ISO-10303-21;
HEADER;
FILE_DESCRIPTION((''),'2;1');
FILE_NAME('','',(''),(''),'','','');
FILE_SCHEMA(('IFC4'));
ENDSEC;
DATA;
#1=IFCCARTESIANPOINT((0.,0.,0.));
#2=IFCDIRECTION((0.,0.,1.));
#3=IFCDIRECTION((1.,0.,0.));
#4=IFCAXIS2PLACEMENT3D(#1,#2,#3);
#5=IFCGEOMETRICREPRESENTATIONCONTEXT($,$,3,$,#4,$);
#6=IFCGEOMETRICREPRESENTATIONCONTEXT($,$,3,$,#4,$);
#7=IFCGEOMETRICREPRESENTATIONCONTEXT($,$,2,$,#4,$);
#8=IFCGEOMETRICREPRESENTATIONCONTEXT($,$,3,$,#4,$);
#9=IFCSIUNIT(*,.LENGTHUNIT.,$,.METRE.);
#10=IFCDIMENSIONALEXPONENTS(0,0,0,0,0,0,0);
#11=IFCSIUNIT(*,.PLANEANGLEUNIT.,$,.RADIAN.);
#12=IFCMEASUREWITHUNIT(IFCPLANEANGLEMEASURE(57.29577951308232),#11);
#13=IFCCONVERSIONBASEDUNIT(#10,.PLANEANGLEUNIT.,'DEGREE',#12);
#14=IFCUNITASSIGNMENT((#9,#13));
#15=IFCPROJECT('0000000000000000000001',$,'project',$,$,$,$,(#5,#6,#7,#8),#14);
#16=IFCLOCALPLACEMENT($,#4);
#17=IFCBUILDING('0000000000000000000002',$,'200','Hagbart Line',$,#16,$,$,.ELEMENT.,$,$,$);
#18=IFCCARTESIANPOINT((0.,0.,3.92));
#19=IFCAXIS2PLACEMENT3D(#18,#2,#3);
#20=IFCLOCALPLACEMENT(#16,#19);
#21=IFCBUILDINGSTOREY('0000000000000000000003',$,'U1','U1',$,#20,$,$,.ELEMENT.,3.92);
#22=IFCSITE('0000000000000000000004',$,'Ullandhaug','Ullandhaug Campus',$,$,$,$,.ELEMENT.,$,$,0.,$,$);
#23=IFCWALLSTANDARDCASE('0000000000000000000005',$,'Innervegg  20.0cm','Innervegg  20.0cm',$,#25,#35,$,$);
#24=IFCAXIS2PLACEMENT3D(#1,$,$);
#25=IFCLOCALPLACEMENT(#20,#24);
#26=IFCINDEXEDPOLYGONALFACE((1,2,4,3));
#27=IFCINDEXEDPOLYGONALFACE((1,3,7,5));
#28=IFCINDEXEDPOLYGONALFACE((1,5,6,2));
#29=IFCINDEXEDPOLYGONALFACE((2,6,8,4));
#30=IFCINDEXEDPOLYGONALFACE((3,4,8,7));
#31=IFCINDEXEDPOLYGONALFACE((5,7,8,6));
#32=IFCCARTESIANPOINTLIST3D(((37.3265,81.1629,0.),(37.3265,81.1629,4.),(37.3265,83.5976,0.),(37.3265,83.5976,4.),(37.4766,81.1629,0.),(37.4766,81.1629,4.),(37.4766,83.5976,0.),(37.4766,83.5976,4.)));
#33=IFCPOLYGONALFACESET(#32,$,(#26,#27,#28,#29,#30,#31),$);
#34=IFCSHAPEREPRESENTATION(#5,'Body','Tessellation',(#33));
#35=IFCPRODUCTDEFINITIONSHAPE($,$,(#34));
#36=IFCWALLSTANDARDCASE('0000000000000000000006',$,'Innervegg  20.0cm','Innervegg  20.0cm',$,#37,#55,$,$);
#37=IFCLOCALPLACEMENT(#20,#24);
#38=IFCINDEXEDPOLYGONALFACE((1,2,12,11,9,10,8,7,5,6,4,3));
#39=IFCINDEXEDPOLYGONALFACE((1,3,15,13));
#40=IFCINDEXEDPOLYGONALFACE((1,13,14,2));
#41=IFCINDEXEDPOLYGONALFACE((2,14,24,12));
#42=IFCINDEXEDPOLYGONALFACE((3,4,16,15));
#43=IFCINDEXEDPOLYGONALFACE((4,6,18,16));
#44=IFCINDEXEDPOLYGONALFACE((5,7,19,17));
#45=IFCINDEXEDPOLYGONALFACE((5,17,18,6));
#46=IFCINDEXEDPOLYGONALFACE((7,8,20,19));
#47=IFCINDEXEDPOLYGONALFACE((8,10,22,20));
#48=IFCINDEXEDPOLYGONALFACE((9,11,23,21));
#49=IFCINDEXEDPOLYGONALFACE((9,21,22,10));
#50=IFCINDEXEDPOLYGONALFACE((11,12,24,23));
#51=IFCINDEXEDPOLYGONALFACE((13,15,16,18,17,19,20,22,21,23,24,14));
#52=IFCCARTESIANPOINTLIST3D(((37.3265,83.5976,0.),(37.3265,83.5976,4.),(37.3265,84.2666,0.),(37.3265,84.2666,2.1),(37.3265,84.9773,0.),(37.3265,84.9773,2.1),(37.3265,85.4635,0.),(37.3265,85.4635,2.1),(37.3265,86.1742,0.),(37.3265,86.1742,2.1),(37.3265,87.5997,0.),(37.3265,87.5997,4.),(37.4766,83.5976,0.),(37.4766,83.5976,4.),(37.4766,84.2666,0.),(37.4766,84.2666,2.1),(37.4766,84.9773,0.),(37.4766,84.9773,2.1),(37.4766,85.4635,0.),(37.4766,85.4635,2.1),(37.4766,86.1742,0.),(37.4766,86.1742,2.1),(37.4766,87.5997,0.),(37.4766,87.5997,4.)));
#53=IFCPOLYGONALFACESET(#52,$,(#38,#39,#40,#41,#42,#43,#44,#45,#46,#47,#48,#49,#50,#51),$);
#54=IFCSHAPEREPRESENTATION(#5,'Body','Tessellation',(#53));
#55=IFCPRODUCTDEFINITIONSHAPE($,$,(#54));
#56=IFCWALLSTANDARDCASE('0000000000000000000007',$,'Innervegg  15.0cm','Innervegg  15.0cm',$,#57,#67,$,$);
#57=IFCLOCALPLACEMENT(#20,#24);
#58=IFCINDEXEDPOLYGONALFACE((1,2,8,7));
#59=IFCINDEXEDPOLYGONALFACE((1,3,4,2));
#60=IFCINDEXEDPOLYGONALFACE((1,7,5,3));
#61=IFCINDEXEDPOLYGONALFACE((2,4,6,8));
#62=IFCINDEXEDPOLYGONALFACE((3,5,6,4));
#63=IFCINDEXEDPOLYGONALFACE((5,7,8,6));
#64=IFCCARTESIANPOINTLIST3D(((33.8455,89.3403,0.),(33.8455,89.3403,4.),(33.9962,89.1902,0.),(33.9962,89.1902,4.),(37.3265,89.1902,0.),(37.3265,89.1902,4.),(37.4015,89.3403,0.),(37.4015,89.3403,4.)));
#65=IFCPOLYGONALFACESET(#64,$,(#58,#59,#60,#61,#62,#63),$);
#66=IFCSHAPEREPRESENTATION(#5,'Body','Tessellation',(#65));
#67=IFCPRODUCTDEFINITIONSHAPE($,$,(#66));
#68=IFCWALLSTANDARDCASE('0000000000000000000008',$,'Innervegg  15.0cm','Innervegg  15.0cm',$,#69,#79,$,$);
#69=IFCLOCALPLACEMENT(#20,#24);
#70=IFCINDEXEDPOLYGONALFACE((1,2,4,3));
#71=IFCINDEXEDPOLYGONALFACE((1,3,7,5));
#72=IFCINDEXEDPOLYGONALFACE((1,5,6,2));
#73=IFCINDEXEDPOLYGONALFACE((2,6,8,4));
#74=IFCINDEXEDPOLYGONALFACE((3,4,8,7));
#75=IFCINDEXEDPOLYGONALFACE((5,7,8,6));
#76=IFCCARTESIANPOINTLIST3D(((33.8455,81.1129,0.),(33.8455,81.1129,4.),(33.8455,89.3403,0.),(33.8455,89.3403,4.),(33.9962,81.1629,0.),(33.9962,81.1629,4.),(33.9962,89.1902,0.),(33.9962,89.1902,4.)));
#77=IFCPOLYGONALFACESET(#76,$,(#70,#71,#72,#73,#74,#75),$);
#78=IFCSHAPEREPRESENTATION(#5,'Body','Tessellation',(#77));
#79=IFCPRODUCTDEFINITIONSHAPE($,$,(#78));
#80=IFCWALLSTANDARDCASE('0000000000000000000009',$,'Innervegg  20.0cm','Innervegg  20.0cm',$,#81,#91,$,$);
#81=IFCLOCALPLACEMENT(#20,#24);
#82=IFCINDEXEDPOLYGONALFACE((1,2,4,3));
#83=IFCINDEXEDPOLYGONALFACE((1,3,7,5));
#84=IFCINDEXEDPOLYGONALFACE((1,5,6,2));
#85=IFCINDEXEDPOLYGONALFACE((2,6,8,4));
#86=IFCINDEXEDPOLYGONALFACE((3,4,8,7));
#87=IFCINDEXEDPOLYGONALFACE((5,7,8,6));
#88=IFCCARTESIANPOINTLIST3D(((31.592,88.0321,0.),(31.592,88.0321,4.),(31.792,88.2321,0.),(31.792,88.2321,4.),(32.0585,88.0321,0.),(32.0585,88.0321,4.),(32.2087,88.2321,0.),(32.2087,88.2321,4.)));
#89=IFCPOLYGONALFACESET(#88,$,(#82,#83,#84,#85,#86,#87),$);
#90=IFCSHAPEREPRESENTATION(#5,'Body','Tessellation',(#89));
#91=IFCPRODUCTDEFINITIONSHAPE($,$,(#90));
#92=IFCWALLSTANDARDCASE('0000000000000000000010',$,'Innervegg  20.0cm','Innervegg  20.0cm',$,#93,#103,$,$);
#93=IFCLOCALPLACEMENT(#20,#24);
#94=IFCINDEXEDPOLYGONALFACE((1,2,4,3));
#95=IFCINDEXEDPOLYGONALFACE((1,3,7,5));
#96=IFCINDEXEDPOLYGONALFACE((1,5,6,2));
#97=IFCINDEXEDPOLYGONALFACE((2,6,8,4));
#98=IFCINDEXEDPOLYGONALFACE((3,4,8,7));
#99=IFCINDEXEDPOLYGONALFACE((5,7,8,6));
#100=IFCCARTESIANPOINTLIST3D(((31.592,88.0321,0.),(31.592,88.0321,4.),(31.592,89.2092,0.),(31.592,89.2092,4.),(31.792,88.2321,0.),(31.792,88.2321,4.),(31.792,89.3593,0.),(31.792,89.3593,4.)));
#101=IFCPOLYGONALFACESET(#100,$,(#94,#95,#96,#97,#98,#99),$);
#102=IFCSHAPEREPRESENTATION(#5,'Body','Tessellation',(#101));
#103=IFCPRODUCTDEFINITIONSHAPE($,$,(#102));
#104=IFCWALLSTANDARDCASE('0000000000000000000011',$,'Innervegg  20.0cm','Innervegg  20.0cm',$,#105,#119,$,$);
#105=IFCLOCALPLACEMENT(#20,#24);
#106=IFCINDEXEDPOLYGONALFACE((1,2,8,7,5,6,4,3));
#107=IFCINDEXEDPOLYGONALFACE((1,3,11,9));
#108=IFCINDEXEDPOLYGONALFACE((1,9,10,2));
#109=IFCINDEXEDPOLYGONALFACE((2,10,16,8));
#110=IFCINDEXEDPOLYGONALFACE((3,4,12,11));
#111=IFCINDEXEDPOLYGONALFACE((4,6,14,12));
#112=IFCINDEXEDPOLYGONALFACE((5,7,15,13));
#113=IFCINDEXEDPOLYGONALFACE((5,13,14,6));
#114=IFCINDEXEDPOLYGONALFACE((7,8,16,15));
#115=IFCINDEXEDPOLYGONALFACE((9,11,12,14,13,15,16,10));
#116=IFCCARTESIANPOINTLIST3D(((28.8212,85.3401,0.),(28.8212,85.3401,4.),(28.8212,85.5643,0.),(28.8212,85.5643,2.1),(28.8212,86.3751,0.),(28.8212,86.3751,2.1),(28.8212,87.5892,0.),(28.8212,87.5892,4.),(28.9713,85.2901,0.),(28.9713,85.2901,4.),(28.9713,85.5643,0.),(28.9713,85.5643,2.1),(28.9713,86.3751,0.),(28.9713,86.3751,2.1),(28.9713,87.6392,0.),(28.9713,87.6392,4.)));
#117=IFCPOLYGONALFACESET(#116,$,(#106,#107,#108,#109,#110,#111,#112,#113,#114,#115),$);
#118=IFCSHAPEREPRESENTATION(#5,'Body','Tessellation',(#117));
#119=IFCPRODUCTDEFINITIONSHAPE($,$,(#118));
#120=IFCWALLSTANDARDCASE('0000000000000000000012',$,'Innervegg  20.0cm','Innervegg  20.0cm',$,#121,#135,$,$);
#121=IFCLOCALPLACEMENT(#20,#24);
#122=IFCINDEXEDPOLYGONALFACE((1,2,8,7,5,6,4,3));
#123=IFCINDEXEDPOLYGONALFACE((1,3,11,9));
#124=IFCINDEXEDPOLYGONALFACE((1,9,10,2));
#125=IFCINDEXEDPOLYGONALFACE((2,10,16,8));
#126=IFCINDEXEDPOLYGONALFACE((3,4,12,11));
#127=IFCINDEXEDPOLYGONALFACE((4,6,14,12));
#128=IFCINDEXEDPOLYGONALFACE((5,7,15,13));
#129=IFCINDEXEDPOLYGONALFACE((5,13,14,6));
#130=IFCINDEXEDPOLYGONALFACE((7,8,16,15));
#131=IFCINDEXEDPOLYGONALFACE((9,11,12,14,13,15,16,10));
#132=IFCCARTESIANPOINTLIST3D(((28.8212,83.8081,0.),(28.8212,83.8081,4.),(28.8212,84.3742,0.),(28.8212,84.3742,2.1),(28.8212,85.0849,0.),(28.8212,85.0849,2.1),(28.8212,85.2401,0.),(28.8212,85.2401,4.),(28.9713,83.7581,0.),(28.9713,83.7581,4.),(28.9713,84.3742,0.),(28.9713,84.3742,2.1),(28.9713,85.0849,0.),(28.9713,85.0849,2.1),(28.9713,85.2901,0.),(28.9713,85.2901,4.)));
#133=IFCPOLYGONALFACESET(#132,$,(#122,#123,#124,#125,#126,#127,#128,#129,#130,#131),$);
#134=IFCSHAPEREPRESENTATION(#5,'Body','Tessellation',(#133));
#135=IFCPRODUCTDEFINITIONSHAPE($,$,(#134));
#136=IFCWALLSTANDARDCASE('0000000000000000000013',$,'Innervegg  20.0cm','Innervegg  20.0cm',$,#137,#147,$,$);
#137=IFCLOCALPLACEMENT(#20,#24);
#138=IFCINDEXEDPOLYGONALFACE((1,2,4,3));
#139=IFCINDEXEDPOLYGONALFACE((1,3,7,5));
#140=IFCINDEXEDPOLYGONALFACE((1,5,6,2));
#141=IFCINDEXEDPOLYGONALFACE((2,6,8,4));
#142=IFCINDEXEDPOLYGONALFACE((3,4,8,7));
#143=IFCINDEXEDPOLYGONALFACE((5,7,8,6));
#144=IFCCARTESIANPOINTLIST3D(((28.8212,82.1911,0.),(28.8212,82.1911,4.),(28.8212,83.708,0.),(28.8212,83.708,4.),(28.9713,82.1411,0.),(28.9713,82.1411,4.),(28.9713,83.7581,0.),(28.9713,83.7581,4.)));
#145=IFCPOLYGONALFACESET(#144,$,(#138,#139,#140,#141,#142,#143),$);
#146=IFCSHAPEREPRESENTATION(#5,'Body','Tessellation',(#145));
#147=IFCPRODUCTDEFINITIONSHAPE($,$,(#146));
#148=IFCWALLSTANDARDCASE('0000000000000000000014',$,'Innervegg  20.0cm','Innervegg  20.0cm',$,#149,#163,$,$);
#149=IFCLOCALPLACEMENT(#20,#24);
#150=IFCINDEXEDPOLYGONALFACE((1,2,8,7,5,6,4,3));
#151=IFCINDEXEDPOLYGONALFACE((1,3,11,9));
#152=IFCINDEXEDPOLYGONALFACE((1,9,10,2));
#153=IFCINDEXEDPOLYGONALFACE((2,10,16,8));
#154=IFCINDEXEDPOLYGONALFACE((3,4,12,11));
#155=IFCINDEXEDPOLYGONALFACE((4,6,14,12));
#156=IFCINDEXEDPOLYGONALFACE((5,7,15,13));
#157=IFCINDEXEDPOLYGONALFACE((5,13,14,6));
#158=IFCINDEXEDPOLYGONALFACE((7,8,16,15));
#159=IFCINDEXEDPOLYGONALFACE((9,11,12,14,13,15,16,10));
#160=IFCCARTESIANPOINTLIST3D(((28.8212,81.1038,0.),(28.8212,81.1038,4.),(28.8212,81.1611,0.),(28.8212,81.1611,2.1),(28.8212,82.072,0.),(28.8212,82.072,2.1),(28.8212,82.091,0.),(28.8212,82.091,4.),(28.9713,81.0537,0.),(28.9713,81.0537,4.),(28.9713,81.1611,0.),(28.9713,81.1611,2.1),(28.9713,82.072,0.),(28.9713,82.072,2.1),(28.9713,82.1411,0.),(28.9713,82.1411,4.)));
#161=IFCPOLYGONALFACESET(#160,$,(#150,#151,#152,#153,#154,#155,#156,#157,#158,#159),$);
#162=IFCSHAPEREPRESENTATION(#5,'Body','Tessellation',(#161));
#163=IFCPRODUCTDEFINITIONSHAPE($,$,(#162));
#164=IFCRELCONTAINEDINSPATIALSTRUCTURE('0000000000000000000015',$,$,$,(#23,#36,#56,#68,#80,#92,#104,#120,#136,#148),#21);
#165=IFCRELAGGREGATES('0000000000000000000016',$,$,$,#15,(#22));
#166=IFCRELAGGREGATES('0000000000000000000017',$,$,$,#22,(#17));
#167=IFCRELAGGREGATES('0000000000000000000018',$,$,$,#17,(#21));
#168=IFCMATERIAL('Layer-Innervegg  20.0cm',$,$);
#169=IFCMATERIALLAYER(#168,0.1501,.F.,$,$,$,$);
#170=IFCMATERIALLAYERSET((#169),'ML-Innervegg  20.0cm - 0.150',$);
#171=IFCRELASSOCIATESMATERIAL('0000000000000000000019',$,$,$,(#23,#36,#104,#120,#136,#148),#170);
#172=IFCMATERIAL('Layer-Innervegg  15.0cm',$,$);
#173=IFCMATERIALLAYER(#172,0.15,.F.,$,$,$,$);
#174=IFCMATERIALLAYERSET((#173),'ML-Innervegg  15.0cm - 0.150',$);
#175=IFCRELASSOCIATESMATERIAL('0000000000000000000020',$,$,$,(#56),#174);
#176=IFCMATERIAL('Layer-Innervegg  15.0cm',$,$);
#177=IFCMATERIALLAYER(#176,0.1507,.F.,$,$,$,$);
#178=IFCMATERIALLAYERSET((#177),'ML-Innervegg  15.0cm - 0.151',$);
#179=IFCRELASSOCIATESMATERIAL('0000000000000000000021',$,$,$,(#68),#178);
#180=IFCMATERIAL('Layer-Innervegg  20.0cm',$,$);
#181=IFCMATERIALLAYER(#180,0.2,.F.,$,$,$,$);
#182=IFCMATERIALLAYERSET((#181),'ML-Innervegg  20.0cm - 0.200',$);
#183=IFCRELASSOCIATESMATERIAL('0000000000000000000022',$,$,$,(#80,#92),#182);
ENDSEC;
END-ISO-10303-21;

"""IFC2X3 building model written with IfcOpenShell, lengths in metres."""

from ifc_helpers import new_model, entity, si_unit, converted_unit, frame, origin_with_axes, place, context, project, spatial, polyline, outline, extrude, material, layer, layer_set, layer_usage, element, save


model = new_model("IFC2X3")

# Units and contexts
context_of_model_1 = context(None, 3, world=origin_with_axes())
context_of_model_2 = context(None, 3, world=origin_with_axes())
context_of_model_3 = context(None, 2, world=origin_with_axes())
context_of_model_4 = context(None, 3, world=origin_with_axes())
ifc_project = project(units=[si_unit("LENGTHUNIT", "METRE"), converted_unit("PLANEANGLEUNIT", "DEGREE", entity("IfcPlaneAngleMeasure", 57.29577951308232), si_unit("PLANEANGLEUNIT", "RADIAN"), dimensions=[0, 0, 0, 0, 0, 0, 0])], contexts=[context_of_model_1, context_of_model_2, context_of_model_3, context_of_model_4])

# Site, building, storey
site = spatial("IfcSite", under=ifc_project, Name="Ullandhaug", Description="Ullandhaug Campus", CompositionType="ELEMENT", RefElevation=0.0)
building_placement = place(None, origin_with_axes())
building = spatial("IfcBuilding", under=site, at=building_placement, Name="200", Description="Hagbart Line", CompositionType="ELEMENT")
storey_placement = place(building_placement, frame((0.0, 0.0, 3.92), z_axis=(0.0, 0.0, 1.0), x_axis=(1.0, 0.0, 0.0)))
storey = spatial("IfcBuildingStorey", under=building, at=storey_placement, Name="U1", Description="U1", CompositionType="ELEMENT", Elevation=3.92)

# Shared definitions
ifc_material_1 = material(Name="Layer-Innervegg  20.0cm")
ifc_layer_1 = layer(ifc_material_1, 0.1501, ventilated=False)
ifc_layer_set_1 = layer_set([ifc_layer_1], Name="ML-Innervegg  20.0cm - 0.150")
ifc_layer_usage_1 = layer_usage(ifc_layer_set_1, "AXIS2", "POSITIVE", 0.0)

# Shared definitions
ifc_material_2 = material(Name="Layer-Innervegg  20.0cm")
ifc_layer_2 = layer(ifc_material_2, 0.2, ventilated=False)
ifc_layer_set_2 = layer_set([ifc_layer_2], Name="ML-Innervegg  20.0cm - 0.200")
ifc_layer_usage_2 = layer_usage(ifc_layer_set_2, "AXIS2", "POSITIVE", 0.0)
ifc_material_3 = material(Name="Layer-Innervegg  15.0cm")
ifc_layer_3 = layer(ifc_material_3, 0.15, ventilated=False)
ifc_layer_set_3 = layer_set([ifc_layer_3], Name="ML-Innervegg  15.0cm - 0.150")
ifc_layer_usage_3 = layer_usage(ifc_layer_set_3, "AXIS2", "POSITIVE", 0.0)

# Wall
wall_1_placement = place(storey_placement, frame((37.3265, 83.5976, 0.0), z_axis=(0.0, 0.0, 1.0), x_axis=(0.0, -1.0, 0.0)))
element("IfcWallStandardCase", 1, at=wall_1_placement, inside=storey, material=ifc_layer_usage_1, Name="Innervegg  20.0cm", Description="Innervegg  20.0cm", context=context_of_model_1, shape_type="SweptSolid", body=[
    extrude(outline(polyline([(0.0, 0.0), (2.4347, 0.0), (2.4347, 0.1502), (0.0, 0.1502), (0.0, 0.0)])), frame((0.0, 0.0, 0.0), z_axis=(0.0, 0.0, 1.0), x_axis=(1.0, 0.0, 0.0)), (0.0, 0.0, 1.0), 4.0),
])

# Wall, openings
wall_2_placement = place(storey_placement, frame((37.4766, 83.5976, 0.0), z_axis=(0.0, 0.0, 1.0), x_axis=(0.0, 1.0, 0.0)))
wall_2 = element("IfcWallStandardCase", 2, at=wall_2_placement, inside=storey, material=ifc_layer_usage_1, Name="Innervegg  20.0cm", Description="Innervegg  20.0cm", context=context_of_model_1, shape_type="SweptSolid", body=[
    extrude(outline(polyline([(0.0, 0.0), (4.0021, 0.0), (4.0021, 0.1502), (0.0, 0.1502), (0.0, 0.0)])), frame((0.0, 0.0, 0.0), z_axis=(0.0, 0.0, 1.0), x_axis=(1.0, 0.0, 0.0)), (0.0, 0.0, 1.0), 4.0),
])
opening_1_placement = place(wall_2_placement, frame((1.8659, 0.1502, 0.0), z_axis=(0.0, 0.0, 1.0), x_axis=(1.0, 0.0, 0.0)))
element("IfcOpeningElement", 3, at=opening_1_placement, cuts=wall_2, context=context_of_model_1, shape_type="SweptSolid", body=[
    extrude(outline(polyline([(0.0, 0.0), (2.1, 0.0), (2.1, 0.7107), (0.0, 0.7107), (0.0, 0.0)])), frame((0.0, 0.0, 0.0), z_axis=(0.0, 1.0, 0.0), x_axis=(0.0, 0.0, 1.0)), (0.0, 0.0, -1.0), 0.1502),
])
opening_2_placement = place(wall_2_placement, frame((0.6691, 0.1502, 0.0), z_axis=(0.0, 0.0, 1.0), x_axis=(1.0, 0.0, 0.0)))
element("IfcOpeningElement", 4, at=opening_2_placement, cuts=wall_2, context=context_of_model_1, shape_type="SweptSolid", body=[
    extrude(outline(polyline([(0.0, 0.0), (2.1, 0.0), (2.1, 0.7107), (0.0, 0.7107), (0.0, 0.0)])), frame((0.0, 0.0, 0.0), z_axis=(0.0, 1.0, 0.0), x_axis=(0.0, 0.0, 1.0)), (0.0, 0.0, -1.0), 0.1502),
])

# Walls
wall_3_placement = place(storey_placement, frame((37.4015, 89.3403, 0.0), z_axis=(0.0, 0.0, 1.0), x_axis=(-1.0, 0.0, 0.0)))
element("IfcWallStandardCase", 5, at=wall_3_placement, inside=storey, material=ifc_layer_usage_3, Name="Innervegg  15.0cm", Description="Innervegg  15.0cm", context=context_of_model_1, shape_type="SweptSolid", body=[
    extrude(outline(polyline([(0.0, 0.0), (3.556, 0.0), (3.4053, 0.1501), (0.0751, 0.1501), (0.0, 0.0)])), frame((0.0, 0.0, 0.0), z_axis=(0.0, 0.0, 1.0), x_axis=(1.0, 0.0, 0.0)), (0.0, 0.0, 1.0), 4.0),
])
ifc_material_4 = material(Name="Layer-Innervegg  15.0cm")
ifc_layer_4 = layer(ifc_material_4, 0.1507, ventilated=False)
ifc_layer_set_4 = layer_set([ifc_layer_4], Name="ML-Innervegg  15.0cm - 0.151")
ifc_layer_usage_4 = layer_usage(ifc_layer_set_4, "AXIS2", "POSITIVE", 0.0)
wall_4_placement = place(storey_placement, frame((33.8455, 89.3403, 0.0), z_axis=(0.0, 0.0, 1.0), x_axis=(0.0, -1.0, 0.0)))
element("IfcWallStandardCase", 6, at=wall_4_placement, inside=storey, material=ifc_layer_usage_4, Name="Innervegg  15.0cm", Description="Innervegg  15.0cm", context=context_of_model_1, shape_type="SweptSolid", body=[
    extrude(outline(polyline([(0.0, 0.0), (8.2275, 0.0), (8.1774, 0.1507), (0.1501, 0.1507), (0.0, 0.0)])), frame((0.0, 0.0, 0.0), z_axis=(0.0, 0.0, 1.0), x_axis=(1.0, 0.0, 0.0)), (0.0, 0.0, 1.0), 4.0),
])
wall_5_placement = place(storey_placement, frame((32.2087, 88.2321, 0.0), z_axis=(0.0, 0.0, 1.0), x_axis=(-1.0, 0.0, 0.0)))
element("IfcWallStandardCase", 7, at=wall_5_placement, inside=storey, material=ifc_layer_usage_2, Name="Innervegg  20.0cm", Description="Innervegg  20.0cm", context=context_of_model_1, shape_type="SweptSolid", body=[
    extrude(outline(polyline([(0.0, 0.0), (0.4167, 0.0), (0.6167, 0.2), (0.1501, 0.2), (0.0, 0.0)])), frame((0.0, 0.0, 0.0), z_axis=(0.0, 0.0, 1.0), x_axis=(1.0, 0.0, 0.0)), (0.0, 0.0, 1.0), 4.0),
])
wall_6_placement = place(storey_placement, frame((31.792, 88.2321, 0.0), z_axis=(0.0, 0.0, 1.0), x_axis=(0.0, 1.0, 0.0)))
element("IfcWallStandardCase", 8, at=wall_6_placement, inside=storey, material=ifc_layer_usage_2, Name="Innervegg  20.0cm", Description="Innervegg  20.0cm", context=context_of_model_1, shape_type="SweptSolid", body=[
    extrude(outline(polyline([(0.0, 0.0), (1.1272, 0.0), (0.9771, 0.2), (-0.2, 0.2), (0.0, 0.0)])), frame((0.0, 0.0, 0.0), z_axis=(0.0, 0.0, 1.0), x_axis=(1.0, 0.0, 0.0)), (0.0, 0.0, 1.0), 4.0),
])

# Walls, openings
wall_7_placement = place(storey_placement, frame((28.8212, 87.5892, 0.0), z_axis=(0.0, 0.0, 1.0), x_axis=(0.0, -1.0, 0.0)))
wall_7 = element("IfcWallStandardCase", 9, at=wall_7_placement, inside=storey, material=ifc_layer_usage_1, Name="Innervegg  20.0cm", Description="Innervegg  20.0cm", context=context_of_model_1, shape_type="SweptSolid", body=[
    extrude(outline(polyline([(0.0, 0.0), (2.249, 0.0), (2.2991, 0.1501), (-0.05, 0.1501), (0.0, 0.0)])), frame((0.0, 0.0, 0.0), z_axis=(0.0, 0.0, 1.0), x_axis=(1.0, 0.0, 0.0)), (0.0, 0.0, 1.0), 4.0),
])
opening_3_placement = place(wall_7_placement, frame((1.2141, 0.1501, 0.0), z_axis=(0.0, 0.0, 1.0), x_axis=(1.0, 0.0, 0.0)))
element("IfcOpeningElement", 10, at=opening_3_placement, cuts=wall_7, context=context_of_model_1, shape_type="SweptSolid", body=[
    extrude(outline(polyline([(0.0, 0.0), (2.1, 0.0), (2.1, 0.8108), (0.0, 0.8108), (0.0, 0.0)])), frame((0.0, 0.0, 0.0), z_axis=(0.000001, 1.0, 0.0), x_axis=(0.0, 0.0, 1.0)), (0.0, 0.000001, -1.0), 0.1501),
])
wall_8_placement = place(storey_placement, frame((28.8212, 85.2401, 0.0), z_axis=(0.0, 0.0, 1.0), x_axis=(0.0, -1.0, 0.0)))
wall_8 = element("IfcWallStandardCase", 11, at=wall_8_placement, inside=storey, material=ifc_layer_usage_1, Name="Innervegg  20.0cm", Description="Innervegg  20.0cm", context=context_of_model_1, shape_type="SweptSolid", body=[
    extrude(outline(polyline([(0.0, 0.0), (1.4319, 0.0), (1.482, 0.1501), (-0.05, 0.1501), (0.0, 0.0)])), frame((0.0, 0.0, 0.0), z_axis=(0.0, 0.0, 1.0), x_axis=(1.0, 0.0, 0.0)), (0.0, 0.0, 1.0), 4.0),
])
opening_4_placement = place(wall_8_placement, frame((0.1551, 0.1501, 0.0), z_axis=(0.0, 0.0, 1.0), x_axis=(1.0, 0.0, 0.0)))
element("IfcOpeningElement", 12, at=opening_4_placement, cuts=wall_8, context=context_of_model_1, shape_type="SweptSolid", body=[
    extrude(outline(polyline([(0.0, 0.0), (2.1, 0.0), (2.1, 0.7107), (0.0, 0.7107), (0.0, 0.0)])), frame((0.0, 0.0, 0.0), z_axis=(0.0, 1.0, 0.0), x_axis=(0.0, 0.0, 1.0)), (0.0, 0.0, -1.0), 0.1501),
])

# Wall
wall_9_placement = place(storey_placement, frame((28.8212, 83.708, 0.0), z_axis=(0.0, 0.0, 1.0), x_axis=(0.0, -1.0, 0.0)))
element("IfcWallStandardCase", 13, at=wall_9_placement, inside=storey, material=ifc_layer_usage_1, Name="Innervegg  20.0cm", Description="Innervegg  20.0cm", context=context_of_model_1, shape_type="SweptSolid", body=[
    extrude(outline(polyline([(0.0, 0.0), (1.5169, 0.0), (1.5669, 0.1501), (-0.05, 0.1501), (0.0, 0.0)])), frame((0.0, 0.0, 0.0), z_axis=(0.0, 0.0, 1.0), x_axis=(1.0, 0.0, 0.0)), (0.0, 0.0, 1.0), 4.0),
])

# Wall, opening
wall_10_placement = place(storey_placement, frame((28.8212, 82.091, 0.0), z_axis=(0.0, 0.0, 1.0), x_axis=(0.000002, -1.0, 0.0)))
wall_10 = element("IfcWallStandardCase", 14, at=wall_10_placement, inside=storey, material=ifc_layer_usage_1, Name="Innervegg  20.0cm", Description="Innervegg  20.0cm", context=context_of_model_1, shape_type="SweptSolid", body=[
    extrude(outline(polyline([(0.0, 0.0), (0.9873, 0.0), (1.0373, 0.1501), (-0.05, 0.1501), (0.0, 0.0)])), frame((0.0, 0.0, 0.0), z_axis=(0.0, 0.0, 1.0), x_axis=(1.0, 0.0, 0.0)), (0.0, 0.0, 1.0), 4.0),
])
opening_5_placement = place(wall_10_placement, frame((0.019, 0.1501, 0.0), z_axis=(0.0, 0.0, 1.0), x_axis=(1.0, 0.0, 0.0)))
element("IfcOpeningElement", 15, at=opening_5_placement, cuts=wall_10, context=context_of_model_1, shape_type="SweptSolid", body=[
    extrude(outline(polyline([(0.0, 0.0), (2.1, 0.0), (2.1, 0.9109), (0.0, 0.9109), (0.0, 0.0)])), frame((0.0, 0.0, 0.0), z_axis=(0.000002, 1.0, 0.0), x_axis=(0.0, 0.0, 1.0)), (0.0, 0.000002, -1.0), 0.1501),
])

save(model, "model.ifc")
